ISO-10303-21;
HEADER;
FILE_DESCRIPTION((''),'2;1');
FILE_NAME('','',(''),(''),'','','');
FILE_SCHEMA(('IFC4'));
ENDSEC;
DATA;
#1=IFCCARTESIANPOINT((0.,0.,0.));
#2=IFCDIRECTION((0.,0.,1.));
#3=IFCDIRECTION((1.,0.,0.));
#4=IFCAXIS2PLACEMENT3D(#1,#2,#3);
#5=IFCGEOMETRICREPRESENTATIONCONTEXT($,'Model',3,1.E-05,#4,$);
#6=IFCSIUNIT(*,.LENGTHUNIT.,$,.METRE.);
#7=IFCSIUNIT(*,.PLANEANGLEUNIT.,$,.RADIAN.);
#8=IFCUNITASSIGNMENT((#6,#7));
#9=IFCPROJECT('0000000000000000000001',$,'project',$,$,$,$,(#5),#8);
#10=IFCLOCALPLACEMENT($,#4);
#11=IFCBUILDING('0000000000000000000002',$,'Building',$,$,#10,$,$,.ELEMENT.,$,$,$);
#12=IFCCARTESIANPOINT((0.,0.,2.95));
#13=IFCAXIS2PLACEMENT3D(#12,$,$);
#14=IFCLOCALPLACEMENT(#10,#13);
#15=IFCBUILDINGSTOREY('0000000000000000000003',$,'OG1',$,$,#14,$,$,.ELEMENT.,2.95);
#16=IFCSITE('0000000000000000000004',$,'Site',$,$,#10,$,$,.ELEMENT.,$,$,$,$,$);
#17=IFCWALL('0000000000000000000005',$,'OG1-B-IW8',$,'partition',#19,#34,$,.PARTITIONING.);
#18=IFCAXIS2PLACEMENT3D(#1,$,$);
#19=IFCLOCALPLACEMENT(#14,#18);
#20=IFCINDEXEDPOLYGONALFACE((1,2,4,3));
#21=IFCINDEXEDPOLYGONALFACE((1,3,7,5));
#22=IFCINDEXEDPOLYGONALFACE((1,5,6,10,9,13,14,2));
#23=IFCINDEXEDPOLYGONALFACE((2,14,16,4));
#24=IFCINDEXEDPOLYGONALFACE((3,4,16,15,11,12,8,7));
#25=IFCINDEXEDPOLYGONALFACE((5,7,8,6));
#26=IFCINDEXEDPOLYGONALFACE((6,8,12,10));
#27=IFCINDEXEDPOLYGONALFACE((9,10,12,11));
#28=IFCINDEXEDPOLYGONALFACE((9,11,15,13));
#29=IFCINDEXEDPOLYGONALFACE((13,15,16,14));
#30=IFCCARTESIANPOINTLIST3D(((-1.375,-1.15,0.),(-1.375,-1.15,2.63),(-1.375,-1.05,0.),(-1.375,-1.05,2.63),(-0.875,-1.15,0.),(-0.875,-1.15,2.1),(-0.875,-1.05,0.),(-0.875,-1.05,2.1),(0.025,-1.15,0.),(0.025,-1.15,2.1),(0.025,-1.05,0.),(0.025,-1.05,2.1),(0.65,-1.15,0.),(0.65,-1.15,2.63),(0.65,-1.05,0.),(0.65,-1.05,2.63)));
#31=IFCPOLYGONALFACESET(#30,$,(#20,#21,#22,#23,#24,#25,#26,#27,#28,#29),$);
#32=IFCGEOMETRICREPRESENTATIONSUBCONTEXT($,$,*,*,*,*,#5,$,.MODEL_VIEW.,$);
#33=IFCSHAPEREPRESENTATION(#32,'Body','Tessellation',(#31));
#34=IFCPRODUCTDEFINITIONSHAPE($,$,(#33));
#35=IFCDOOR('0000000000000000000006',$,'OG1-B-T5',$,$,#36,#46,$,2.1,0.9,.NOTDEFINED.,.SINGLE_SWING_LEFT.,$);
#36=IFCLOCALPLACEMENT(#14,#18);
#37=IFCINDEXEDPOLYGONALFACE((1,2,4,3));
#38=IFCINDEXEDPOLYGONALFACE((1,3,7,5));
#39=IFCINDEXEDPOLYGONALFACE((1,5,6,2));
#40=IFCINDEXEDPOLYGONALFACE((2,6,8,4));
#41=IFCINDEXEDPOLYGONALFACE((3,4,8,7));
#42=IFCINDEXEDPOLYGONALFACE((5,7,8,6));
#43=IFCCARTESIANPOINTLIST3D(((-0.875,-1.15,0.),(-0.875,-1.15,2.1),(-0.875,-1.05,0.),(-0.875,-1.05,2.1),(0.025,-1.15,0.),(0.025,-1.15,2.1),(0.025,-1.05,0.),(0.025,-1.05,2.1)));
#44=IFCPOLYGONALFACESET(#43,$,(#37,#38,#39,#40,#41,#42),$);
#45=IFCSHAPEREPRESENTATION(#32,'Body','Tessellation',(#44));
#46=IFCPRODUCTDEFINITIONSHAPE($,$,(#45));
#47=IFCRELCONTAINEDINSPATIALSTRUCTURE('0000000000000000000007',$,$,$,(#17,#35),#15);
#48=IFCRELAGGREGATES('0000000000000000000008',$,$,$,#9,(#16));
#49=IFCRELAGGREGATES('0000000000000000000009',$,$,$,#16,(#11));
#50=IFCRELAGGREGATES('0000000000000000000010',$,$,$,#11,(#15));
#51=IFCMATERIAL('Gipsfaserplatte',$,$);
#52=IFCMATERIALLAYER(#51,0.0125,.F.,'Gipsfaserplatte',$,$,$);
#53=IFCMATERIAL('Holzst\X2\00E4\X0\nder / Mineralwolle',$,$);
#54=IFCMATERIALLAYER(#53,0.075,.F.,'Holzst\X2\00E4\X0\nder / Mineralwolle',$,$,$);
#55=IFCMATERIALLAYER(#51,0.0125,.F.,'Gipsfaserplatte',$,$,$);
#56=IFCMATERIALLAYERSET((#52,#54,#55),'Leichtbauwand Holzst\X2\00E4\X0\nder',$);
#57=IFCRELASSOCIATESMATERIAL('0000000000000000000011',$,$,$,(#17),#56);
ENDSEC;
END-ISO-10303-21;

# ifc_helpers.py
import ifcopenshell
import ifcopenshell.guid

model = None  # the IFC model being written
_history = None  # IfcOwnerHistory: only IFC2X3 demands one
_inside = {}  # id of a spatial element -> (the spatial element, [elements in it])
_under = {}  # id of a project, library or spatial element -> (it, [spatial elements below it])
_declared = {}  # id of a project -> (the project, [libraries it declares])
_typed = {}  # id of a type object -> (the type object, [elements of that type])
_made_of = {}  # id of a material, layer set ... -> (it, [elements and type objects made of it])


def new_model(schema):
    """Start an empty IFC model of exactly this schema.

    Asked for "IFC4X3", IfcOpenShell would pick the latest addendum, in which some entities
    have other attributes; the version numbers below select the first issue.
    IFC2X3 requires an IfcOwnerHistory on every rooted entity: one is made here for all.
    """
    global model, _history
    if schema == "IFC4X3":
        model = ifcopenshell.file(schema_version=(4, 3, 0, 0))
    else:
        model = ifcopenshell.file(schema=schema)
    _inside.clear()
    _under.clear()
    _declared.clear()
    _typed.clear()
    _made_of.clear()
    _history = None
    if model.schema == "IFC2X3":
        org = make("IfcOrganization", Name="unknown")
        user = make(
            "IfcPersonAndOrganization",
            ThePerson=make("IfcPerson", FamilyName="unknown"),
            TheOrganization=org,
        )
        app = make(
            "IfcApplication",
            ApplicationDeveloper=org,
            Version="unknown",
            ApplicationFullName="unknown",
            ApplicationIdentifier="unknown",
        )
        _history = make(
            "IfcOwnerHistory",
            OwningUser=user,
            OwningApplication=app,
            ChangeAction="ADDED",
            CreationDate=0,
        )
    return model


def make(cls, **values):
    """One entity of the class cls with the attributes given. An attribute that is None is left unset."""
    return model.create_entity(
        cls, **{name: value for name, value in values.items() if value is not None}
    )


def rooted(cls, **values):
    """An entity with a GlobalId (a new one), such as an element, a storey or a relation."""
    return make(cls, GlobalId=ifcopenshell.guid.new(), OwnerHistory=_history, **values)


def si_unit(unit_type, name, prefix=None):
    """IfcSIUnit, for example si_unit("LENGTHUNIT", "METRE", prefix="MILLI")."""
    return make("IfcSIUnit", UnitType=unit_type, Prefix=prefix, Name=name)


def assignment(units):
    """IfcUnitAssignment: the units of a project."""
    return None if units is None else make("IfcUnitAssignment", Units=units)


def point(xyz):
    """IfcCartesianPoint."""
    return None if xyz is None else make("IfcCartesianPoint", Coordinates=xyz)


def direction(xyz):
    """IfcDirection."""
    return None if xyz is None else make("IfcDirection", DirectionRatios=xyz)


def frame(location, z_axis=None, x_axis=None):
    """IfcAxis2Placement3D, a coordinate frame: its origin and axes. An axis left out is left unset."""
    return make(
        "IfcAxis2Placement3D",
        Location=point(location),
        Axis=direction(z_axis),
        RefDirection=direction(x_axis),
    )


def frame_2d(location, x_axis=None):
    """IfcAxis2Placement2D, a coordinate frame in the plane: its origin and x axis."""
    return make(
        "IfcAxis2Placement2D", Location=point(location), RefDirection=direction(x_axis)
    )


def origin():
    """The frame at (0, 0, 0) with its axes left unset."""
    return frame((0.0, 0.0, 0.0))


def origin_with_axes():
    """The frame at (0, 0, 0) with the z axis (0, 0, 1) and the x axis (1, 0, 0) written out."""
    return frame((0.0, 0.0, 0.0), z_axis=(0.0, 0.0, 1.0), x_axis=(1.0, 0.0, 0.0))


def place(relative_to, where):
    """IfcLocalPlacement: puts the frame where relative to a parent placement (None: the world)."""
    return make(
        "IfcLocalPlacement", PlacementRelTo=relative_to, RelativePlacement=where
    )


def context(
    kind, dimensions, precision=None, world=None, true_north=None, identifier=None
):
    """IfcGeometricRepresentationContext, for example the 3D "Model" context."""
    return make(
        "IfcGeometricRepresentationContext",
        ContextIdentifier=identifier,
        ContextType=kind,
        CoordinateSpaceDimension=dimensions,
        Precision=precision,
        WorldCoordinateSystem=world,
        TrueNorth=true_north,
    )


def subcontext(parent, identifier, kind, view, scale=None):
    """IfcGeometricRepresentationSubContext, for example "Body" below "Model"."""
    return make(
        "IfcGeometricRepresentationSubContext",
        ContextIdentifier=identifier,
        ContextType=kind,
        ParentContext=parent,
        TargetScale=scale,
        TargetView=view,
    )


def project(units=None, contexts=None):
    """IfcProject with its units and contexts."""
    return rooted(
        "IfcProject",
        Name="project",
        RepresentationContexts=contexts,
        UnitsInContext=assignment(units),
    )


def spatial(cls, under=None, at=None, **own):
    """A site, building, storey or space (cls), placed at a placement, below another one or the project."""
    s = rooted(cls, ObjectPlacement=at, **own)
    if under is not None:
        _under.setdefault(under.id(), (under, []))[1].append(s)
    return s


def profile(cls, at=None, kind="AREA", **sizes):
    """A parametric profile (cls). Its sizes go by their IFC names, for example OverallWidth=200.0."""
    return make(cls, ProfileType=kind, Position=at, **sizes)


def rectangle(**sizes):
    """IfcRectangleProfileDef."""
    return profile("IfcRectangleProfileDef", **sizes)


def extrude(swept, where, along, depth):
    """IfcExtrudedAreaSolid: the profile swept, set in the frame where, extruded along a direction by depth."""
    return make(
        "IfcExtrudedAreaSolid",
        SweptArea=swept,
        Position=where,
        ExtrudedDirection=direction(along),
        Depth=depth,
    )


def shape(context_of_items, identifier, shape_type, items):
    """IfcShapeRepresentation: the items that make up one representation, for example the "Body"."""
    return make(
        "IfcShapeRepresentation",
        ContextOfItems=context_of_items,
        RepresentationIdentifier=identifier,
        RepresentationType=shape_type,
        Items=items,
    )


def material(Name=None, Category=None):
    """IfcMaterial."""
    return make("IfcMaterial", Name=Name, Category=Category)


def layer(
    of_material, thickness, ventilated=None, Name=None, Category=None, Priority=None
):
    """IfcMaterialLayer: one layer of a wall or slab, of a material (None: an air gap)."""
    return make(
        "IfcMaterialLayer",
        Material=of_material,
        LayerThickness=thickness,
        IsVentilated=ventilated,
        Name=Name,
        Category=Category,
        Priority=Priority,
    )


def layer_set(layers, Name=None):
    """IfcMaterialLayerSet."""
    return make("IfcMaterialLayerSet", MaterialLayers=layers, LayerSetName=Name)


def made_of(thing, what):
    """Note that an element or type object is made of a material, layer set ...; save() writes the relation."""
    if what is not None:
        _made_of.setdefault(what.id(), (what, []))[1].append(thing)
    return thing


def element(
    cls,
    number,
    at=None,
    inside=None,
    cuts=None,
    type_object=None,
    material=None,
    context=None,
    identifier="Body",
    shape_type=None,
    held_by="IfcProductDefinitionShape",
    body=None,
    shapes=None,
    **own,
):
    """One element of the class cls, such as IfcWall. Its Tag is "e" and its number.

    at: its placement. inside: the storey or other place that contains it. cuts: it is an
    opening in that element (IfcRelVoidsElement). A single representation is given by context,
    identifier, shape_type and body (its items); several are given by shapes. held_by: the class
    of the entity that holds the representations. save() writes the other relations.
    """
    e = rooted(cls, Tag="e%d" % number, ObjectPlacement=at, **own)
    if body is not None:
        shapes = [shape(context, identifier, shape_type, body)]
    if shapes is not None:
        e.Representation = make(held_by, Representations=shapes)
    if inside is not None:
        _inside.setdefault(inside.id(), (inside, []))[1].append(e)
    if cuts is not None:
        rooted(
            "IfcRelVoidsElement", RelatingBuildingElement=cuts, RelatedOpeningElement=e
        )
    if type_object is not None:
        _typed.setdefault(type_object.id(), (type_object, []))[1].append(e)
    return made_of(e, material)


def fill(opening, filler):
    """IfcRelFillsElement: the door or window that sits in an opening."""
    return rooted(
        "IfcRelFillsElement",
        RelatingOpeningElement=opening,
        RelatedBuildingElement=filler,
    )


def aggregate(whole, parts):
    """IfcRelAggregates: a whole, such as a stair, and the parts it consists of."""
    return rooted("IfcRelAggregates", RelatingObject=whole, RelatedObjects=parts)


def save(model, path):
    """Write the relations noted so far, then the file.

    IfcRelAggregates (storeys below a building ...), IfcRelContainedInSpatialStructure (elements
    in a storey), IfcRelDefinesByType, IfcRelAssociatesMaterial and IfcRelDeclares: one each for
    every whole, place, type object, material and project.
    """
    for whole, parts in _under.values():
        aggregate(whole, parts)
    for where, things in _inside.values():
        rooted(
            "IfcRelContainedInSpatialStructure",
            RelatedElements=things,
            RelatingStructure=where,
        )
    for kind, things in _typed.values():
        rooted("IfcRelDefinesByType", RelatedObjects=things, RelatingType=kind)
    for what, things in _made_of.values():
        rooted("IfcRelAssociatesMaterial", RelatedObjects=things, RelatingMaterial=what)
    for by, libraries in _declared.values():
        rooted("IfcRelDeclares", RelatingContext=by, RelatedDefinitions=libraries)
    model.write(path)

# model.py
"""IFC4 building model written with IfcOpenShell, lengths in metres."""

from ifc_helpers import new_model, si_unit, frame, frame_2d, origin, origin_with_axes, place, context, subcontext, project, spatial, rectangle, extrude, material, layer, layer_set, element, fill, save


model = new_model("IFC4")

# Units and contexts
model_context = context("Model", 3, precision=1e-05, world=origin_with_axes())
sub_context = subcontext(model_context, None, None, "MODEL_VIEW")
ifc_project = project(units=[si_unit("LENGTHUNIT", "METRE"), si_unit("PLANEANGLEUNIT", "RADIAN")], contexts=[model_context])

# Site, building, storey
placement = place(None, origin_with_axes())
site = spatial("IfcSite", under=ifc_project, at=placement, Name="Site", CompositionType="ELEMENT")
building = spatial("IfcBuilding", under=site, at=placement, Name="Building", CompositionType="ELEMENT")
storey_placement = place(placement, frame((0.0, 0.0, 2.95)))
storey = spatial("IfcBuildingStorey", under=building, at=storey_placement, Name="OG1", CompositionType="ELEMENT", Elevation=2.95)

# Shared definitions
ifc_material_1 = material(Name="Gipsfaserplatte")

# Shared definitions
ifc_material_2 = material(Name="Holzständer / Mineralwolle")

# Wall, opening, door
ifc_layer_1 = layer(ifc_material_1, 0.0125, ventilated=False, Name="Gipsfaserplatte")
ifc_layer_2 = layer(ifc_material_2, 0.075, ventilated=False, Name="Holzständer / Mineralwolle")
ifc_layer_3 = layer(ifc_material_1, 0.0125, ventilated=False, Name="Gipsfaserplatte")
ifc_layer_set_1 = layer_set([ifc_layer_1, ifc_layer_2, ifc_layer_3], Name="Leichtbauwand Holzständer")
wall_1_placement = place(storey_placement, frame((-1.375, -1.1, 0.0), z_axis=(0.0, 0.0, 1.0), x_axis=(1.0, 0.0, 0.0)))
wall_1 = element("IfcWall", 1, at=wall_1_placement, inside=storey, material=ifc_layer_set_1, Name="OG1-B-IW8", ObjectType="partition", PredefinedType="PARTITIONING", context=sub_context, shape_type="SweptSolid", body=[
    extrude(rectangle(XDim=2.025, YDim=0.1, at=frame_2d((1.0125, 0.0))), origin(), (0.0, 0.0, 1.0), 2.63),
])
opening_1_placement = place(wall_1_placement, frame((0.95, 0.1, 0.0), z_axis=(0.0, -1.0, 0.0), x_axis=(1.0, 0.0, 0.0)))
opening_1 = element("IfcOpeningElement", 2, at=opening_1_placement, cuts=wall_1, PredefinedType="OPENING", context=sub_context, shape_type="SweptSolid", body=[
    extrude(rectangle(XDim=0.9, YDim=2.1, at=frame_2d((0.0, 1.05))), origin(), (0.0, 0.0, 1.0), 0.2),
])
door_1_placement = place(wall_1_placement, frame((0.95, 0.05, 0.0), z_axis=(0.0, -1.0, 0.0), x_axis=(1.0, 0.0, 0.0)))
door_1 = element("IfcDoor", 3, at=door_1_placement, inside=storey, Name="OG1-B-T5", OperationType="SINGLE_SWING_LEFT", OverallHeight=2.1, OverallWidth=0.9, PredefinedType="NOTDEFINED", context=sub_context, shape_type="SweptSolid", body=[
    extrude(rectangle(XDim=0.9, YDim=2.1, at=frame_2d((0.0, 1.05))), origin(), (0.0, 0.0, 1.0), 0.1),
])
fill(opening_1, door_1)

save(model, "model.ifc")
